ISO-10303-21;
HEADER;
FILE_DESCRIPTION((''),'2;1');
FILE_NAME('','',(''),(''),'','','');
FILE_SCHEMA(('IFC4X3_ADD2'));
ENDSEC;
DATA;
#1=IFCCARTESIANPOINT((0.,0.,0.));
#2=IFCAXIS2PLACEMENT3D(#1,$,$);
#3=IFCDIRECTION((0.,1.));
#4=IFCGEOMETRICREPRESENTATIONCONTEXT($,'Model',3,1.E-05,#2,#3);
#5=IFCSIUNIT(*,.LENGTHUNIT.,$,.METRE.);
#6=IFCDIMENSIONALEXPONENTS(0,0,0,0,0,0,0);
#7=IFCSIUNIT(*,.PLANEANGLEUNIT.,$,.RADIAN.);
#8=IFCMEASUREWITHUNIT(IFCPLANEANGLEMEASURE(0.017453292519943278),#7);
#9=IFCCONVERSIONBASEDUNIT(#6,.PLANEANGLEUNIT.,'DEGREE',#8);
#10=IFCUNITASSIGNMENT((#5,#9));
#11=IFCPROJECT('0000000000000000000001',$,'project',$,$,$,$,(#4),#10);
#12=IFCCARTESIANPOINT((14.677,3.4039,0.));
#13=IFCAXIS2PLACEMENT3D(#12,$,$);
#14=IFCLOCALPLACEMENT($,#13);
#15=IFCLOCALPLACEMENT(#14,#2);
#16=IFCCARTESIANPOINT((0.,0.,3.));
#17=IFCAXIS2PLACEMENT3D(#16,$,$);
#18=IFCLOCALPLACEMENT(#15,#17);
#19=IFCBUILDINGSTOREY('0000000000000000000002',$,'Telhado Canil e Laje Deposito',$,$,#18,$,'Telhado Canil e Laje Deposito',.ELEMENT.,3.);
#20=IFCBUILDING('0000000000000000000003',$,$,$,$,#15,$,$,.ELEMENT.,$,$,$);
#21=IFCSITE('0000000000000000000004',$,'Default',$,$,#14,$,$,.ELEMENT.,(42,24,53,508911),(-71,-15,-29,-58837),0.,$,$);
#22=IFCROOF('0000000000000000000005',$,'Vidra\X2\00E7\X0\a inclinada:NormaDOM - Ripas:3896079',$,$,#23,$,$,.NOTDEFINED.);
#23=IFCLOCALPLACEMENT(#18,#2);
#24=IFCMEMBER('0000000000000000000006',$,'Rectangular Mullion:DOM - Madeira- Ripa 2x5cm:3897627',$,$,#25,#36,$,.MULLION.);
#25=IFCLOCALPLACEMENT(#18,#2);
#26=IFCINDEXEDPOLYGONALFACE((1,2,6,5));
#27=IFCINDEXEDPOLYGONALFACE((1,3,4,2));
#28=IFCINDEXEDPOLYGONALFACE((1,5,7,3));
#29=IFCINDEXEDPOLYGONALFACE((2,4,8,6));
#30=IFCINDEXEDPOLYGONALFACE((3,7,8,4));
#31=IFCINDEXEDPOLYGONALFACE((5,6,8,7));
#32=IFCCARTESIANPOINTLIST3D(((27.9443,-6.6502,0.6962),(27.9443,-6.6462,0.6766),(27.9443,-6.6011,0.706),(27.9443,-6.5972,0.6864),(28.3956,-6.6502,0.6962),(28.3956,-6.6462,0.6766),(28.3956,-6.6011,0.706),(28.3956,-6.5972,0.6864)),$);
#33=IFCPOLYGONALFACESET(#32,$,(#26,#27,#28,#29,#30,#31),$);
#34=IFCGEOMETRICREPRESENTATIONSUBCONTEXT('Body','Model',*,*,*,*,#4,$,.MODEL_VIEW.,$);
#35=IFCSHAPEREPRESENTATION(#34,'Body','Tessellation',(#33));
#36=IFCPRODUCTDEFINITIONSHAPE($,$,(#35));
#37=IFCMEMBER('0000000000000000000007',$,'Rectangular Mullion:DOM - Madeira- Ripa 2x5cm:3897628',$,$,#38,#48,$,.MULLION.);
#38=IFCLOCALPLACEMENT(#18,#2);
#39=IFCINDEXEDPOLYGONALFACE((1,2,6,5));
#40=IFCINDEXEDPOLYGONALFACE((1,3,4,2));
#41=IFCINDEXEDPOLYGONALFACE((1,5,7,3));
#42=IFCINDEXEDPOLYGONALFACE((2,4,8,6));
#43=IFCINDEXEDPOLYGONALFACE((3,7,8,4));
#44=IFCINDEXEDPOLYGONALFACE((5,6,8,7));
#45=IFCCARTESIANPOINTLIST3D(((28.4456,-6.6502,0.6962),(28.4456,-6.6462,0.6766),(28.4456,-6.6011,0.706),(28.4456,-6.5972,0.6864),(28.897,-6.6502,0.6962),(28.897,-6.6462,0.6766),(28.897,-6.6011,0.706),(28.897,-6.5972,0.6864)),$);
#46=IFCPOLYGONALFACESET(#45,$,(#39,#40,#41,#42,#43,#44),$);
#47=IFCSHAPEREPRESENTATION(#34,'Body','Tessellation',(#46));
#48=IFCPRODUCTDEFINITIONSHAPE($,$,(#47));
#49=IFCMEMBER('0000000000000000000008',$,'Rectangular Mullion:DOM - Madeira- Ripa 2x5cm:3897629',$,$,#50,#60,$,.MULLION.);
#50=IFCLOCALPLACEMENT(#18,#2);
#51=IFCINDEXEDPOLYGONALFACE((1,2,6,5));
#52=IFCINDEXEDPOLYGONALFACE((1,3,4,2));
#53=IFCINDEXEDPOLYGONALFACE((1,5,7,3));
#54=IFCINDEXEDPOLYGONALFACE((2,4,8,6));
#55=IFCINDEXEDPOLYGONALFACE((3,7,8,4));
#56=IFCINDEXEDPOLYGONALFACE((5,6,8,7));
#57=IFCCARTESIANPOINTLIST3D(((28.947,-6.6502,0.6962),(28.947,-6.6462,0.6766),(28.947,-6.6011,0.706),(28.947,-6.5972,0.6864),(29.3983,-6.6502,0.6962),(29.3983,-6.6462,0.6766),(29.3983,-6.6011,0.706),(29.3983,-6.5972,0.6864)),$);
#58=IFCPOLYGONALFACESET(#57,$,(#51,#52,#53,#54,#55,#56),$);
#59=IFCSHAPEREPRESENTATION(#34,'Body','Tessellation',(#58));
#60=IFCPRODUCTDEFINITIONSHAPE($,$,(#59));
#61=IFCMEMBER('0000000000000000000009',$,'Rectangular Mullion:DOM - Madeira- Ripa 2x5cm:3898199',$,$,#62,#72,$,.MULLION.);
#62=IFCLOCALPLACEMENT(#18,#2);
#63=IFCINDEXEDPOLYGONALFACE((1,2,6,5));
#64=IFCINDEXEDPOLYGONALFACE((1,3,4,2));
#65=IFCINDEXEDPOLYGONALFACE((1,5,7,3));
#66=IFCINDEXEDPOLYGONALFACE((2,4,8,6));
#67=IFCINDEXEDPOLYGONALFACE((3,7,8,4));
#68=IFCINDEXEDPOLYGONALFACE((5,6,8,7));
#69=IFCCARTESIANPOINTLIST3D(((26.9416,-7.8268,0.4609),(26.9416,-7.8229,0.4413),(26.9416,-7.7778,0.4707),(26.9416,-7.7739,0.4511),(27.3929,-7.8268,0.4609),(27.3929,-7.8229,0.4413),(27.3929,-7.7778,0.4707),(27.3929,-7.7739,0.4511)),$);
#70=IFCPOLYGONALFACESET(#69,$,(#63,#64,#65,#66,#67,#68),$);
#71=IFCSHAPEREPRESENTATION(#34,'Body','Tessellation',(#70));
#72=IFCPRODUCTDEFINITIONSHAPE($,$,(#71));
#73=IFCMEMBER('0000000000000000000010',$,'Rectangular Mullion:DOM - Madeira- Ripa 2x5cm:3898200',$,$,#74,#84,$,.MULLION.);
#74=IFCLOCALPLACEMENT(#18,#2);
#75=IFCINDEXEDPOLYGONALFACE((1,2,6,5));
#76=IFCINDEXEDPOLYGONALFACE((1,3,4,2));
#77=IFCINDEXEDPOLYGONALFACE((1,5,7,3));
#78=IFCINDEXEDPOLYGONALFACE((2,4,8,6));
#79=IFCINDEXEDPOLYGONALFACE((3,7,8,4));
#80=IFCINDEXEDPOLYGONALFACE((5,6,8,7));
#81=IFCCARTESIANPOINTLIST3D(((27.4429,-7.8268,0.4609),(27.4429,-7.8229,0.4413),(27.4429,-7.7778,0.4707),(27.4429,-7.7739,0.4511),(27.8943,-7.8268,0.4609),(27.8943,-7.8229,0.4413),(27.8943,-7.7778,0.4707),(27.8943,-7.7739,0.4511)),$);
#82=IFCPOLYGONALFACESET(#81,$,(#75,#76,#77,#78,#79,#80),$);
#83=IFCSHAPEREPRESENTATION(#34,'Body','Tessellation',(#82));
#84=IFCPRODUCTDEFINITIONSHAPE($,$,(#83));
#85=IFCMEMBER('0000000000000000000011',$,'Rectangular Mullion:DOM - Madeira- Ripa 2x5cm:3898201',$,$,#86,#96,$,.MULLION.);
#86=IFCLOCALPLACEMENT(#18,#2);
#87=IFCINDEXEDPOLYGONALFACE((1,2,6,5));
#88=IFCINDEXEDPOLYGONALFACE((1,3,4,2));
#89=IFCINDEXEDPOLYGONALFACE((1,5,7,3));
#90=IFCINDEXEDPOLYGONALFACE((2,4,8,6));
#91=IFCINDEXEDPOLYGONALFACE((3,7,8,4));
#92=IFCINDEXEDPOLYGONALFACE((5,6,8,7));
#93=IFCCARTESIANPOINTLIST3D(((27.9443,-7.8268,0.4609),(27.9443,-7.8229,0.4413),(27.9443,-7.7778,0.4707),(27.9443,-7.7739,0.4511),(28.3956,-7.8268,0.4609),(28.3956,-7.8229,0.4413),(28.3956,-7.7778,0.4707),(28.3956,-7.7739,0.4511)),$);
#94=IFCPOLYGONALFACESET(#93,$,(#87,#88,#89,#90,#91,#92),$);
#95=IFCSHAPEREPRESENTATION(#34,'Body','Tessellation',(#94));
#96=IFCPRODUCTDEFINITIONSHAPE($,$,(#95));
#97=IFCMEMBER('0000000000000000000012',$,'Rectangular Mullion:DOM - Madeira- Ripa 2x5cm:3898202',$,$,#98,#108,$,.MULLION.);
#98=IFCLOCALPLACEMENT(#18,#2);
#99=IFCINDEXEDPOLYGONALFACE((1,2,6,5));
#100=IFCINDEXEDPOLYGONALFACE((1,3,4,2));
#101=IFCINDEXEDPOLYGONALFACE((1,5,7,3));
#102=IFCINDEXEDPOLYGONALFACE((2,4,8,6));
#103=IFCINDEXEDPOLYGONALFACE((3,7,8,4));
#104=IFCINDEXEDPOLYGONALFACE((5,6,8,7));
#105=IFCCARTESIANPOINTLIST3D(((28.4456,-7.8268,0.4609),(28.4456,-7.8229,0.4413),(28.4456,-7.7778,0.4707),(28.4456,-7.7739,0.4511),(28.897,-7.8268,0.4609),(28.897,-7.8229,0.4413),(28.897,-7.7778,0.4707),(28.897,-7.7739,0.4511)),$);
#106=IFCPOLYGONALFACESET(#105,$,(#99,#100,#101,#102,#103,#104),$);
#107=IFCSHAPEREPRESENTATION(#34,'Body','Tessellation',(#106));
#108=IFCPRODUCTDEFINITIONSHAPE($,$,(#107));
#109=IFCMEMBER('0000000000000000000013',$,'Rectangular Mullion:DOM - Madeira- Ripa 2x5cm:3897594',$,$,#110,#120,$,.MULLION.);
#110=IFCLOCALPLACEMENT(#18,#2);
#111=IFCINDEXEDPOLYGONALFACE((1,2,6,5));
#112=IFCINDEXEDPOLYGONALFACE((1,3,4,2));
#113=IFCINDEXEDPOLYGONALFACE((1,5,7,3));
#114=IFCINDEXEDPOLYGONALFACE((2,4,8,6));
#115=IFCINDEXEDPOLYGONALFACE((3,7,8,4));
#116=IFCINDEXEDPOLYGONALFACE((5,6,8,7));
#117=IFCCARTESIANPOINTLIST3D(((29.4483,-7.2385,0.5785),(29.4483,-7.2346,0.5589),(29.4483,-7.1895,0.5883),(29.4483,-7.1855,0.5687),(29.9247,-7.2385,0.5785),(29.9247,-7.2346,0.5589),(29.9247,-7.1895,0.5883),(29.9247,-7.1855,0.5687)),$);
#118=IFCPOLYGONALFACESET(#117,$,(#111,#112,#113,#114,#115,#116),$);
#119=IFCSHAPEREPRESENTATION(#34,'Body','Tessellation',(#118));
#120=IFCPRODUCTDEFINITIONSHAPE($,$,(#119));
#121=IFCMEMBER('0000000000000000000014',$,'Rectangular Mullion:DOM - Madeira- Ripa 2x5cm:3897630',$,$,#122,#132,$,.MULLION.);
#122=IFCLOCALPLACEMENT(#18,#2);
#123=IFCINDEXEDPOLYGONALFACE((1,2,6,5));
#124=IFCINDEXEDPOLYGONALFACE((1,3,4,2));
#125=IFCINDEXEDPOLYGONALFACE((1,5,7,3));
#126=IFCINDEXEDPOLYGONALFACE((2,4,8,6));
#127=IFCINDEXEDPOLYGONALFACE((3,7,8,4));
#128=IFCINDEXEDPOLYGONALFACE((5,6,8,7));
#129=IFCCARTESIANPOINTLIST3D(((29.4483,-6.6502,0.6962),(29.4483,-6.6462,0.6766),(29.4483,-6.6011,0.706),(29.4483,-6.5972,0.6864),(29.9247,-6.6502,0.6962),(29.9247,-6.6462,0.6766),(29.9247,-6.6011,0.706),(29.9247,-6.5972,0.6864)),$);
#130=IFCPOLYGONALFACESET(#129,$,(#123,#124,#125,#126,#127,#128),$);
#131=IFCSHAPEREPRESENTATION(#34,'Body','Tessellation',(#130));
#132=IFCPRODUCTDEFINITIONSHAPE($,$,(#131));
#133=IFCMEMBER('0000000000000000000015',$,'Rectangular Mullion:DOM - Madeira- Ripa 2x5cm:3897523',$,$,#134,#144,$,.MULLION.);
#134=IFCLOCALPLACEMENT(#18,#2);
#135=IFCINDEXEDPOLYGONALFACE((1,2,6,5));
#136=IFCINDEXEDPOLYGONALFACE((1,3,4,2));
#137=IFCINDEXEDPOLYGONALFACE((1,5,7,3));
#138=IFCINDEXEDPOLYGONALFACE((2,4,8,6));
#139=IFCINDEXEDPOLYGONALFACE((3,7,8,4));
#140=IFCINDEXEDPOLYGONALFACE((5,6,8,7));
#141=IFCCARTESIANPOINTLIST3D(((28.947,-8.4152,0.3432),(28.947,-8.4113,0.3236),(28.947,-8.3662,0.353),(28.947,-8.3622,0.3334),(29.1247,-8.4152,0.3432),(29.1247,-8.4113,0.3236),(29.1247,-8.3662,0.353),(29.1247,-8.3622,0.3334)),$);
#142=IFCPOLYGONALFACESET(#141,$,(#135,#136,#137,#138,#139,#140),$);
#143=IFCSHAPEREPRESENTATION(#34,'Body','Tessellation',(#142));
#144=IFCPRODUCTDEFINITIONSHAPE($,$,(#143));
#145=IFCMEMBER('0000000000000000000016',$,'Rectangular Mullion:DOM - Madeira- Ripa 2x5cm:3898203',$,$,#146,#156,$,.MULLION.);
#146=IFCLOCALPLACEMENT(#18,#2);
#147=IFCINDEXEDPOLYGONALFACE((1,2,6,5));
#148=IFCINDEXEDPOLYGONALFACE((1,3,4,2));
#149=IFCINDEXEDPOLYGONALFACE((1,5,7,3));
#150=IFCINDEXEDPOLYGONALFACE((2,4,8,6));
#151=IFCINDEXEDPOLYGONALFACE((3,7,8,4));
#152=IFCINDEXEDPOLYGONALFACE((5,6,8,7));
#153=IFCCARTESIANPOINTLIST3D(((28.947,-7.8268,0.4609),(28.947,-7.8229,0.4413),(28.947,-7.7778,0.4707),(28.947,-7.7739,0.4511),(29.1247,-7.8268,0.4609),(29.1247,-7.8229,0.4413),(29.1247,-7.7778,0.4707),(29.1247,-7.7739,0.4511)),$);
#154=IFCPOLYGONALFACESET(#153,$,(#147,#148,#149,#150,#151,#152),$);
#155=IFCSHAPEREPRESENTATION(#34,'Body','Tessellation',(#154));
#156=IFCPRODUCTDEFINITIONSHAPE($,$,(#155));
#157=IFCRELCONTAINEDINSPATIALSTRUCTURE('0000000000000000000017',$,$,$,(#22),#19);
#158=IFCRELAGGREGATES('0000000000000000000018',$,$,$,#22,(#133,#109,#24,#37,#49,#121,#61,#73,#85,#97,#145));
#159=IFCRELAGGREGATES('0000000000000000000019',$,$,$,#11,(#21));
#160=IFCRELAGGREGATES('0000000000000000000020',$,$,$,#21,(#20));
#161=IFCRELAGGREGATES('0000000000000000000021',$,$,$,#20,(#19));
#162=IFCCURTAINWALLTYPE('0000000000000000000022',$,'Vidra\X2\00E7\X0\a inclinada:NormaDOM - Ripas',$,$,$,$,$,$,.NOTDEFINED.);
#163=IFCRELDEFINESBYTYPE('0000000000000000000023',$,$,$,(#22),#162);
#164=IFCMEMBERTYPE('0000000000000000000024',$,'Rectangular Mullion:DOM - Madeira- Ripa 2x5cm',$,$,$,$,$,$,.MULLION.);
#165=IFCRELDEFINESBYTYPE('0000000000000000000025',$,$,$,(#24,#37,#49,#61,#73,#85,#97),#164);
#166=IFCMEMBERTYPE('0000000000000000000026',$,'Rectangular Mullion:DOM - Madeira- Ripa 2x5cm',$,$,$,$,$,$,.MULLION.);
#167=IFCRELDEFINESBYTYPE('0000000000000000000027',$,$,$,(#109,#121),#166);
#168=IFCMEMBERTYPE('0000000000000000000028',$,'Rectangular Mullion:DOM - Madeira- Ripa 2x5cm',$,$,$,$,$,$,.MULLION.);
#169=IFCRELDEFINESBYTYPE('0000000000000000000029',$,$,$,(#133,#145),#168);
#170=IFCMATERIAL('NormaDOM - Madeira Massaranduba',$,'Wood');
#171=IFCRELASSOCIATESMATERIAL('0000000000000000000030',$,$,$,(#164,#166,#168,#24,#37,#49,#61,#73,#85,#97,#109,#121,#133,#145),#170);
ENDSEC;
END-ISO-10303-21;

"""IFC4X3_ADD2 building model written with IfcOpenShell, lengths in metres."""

from ifc_helpers import new_model, entity, si_unit, converted_unit, direction, frame, origin, origin_2d_with_axis, place, context, subcontext, project, spatial, rectangle, extrude, source, transform, mapped, material, material_profile, profile_set, profile_usage, type_object, type_shapes, element, aggregate, save


model = new_model("IFC4X3_ADD2")

# Units and contexts
model_context = context("Model", 3, precision=1e-05, world=origin(), true_north=direction((0.0, 1.0)))
body_context = subcontext(model_context, "Body", "Model", "MODEL_VIEW")
ifc_project = project(units=[si_unit("LENGTHUNIT", "METRE"), converted_unit("PLANEANGLEUNIT", "DEGREE", entity("IfcPlaneAngleMeasure", 0.017453292519943278), si_unit("PLANEANGLEUNIT", "RADIAN"), dimensions=[0, 0, 0, 0, 0, 0, 0])], contexts=[model_context])

# Site, building, storey
site_placement = place(None, frame((14.677, 3.4039, 0.0)))
site = spatial("IfcSite", under=ifc_project, at=site_placement, Name="Default", CompositionType="ELEMENT", RefLatitude=(42, 24, 53, 508911), RefLongitude=(-71, -15, -29, -58837), RefElevation=0.0)
building_placement = place(site_placement, origin())
building = spatial("IfcBuilding", under=site, at=building_placement, CompositionType="ELEMENT")
storey_placement = place(building_placement, frame((0.0, 0.0, 3.0)))
storey = spatial("IfcBuildingStorey", under=building, at=storey_placement, Name="Telhado Canil e Laje Deposito", LongName="Telhado Canil e Laje Deposito", CompositionType="ELEMENT", Elevation=3.0)

# Roof
ifc_material = material(Name="NormaDOM - Madeira Massaranduba", Category="Wood")
ifc_material_profile_1 = material_profile(ifc_material, rectangle(XDim=0.05, YDim=0.02, at=origin_2d_with_axis()), Name="DOM - Madeira- Ripa 2x5cm")
ifc_profile_set_1 = profile_set([ifc_material_profile_1], Name="DOM - Madeira- Ripa 2x5cm")
ifc_profile_usage_1 = profile_usage(ifc_profile_set_1)
curtain_wall_type_1 = type_object("IfcCurtainWallType", Name="Vidraça inclinada:NormaDOM - Ripas", PredefinedType="NOTDEFINED")
roof_1_placement = place(storey_placement, frame((0.0, 0.0, -3.0)))
roof_1 = element("IfcRoof", 1, at=roof_1_placement, inside=storey, type_object=curtain_wall_type_1, Name="Vidraça inclinada:NormaDOM - Ripas:3896079", PredefinedType="NOTDEFINED")

# Members
member_type_1 = type_object("IfcMemberType", Name="Rectangular Mullion:DOM - Madeira- Ripa 2x5cm", PredefinedType="MULLION", material=ifc_profile_set_1)
shared_shape_1 = source(origin(), body_context, "Body", "SweptSolid", [
    extrude(rectangle(XDim=0.05, YDim=0.02, at=origin_2d_with_axis()), frame((0.025, 0.01, -0.4514), z_axis=(0.0, 0.0, 1.0), x_axis=(-1.0, 0.0, 0.0)), (0.0, 0.0, 1.0), 0.4514),
])
type_shapes(member_type_1, [shared_shape_1])
member_1_placement = place(roof_1_placement, frame((27.9443, -6.6502, 3.6962), z_axis=(-1.0, 0.0, 0.0), x_axis=(0.0, 0.980581, 0.196116)))
member_1 = element("IfcMember", 2, at=member_1_placement, type_object=member_type_1, material=ifc_profile_usage_1, Name="Rectangular Mullion:DOM - Madeira- Ripa 2x5cm:3897627", PredefinedType="MULLION", context=body_context, shape_type="MappedRepresentation", body=[
    mapped(shared_shape_1, transform((0.0, 0.0, 0.0), scale=1.0)),
])
member_2_placement = place(roof_1_placement, frame((28.4456, -6.6502, 3.6962), z_axis=(-1.0, 0.0, 0.0), x_axis=(0.0, 0.980581, 0.196116)))
member_2 = element("IfcMember", 3, at=member_2_placement, type_object=member_type_1, material=ifc_profile_usage_1, Name="Rectangular Mullion:DOM - Madeira- Ripa 2x5cm:3897628", PredefinedType="MULLION", context=body_context, shape_type="MappedRepresentation", body=[
    mapped(shared_shape_1, transform((0.0, 0.0, 0.0), scale=1.0)),
])
member_3_placement = place(roof_1_placement, frame((28.947, -6.6502, 3.6962), z_axis=(-1.0, 0.0, 0.0), x_axis=(0.0, 0.980581, 0.196116)))
member_3 = element("IfcMember", 4, at=member_3_placement, type_object=member_type_1, material=ifc_profile_usage_1, Name="Rectangular Mullion:DOM - Madeira- Ripa 2x5cm:3897629", PredefinedType="MULLION", context=body_context, shape_type="MappedRepresentation", body=[
    mapped(shared_shape_1, transform((0.0, 0.0, 0.0), scale=1.0)),
])
member_4_placement = place(roof_1_placement, frame((26.9416, -7.8268, 3.4609), z_axis=(-1.0, 0.0, 0.0), x_axis=(0.0, 0.980581, 0.196116)))
member_4 = element("IfcMember", 5, at=member_4_placement, type_object=member_type_1, material=ifc_profile_usage_1, Name="Rectangular Mullion:DOM - Madeira- Ripa 2x5cm:3898199", PredefinedType="MULLION", context=body_context, shape_type="MappedRepresentation", body=[
    mapped(shared_shape_1, transform((0.0, 0.0, 0.0), scale=1.0)),
])
member_5_placement = place(roof_1_placement, frame((27.4429, -7.8268, 3.4609), z_axis=(-1.0, 0.0, 0.0), x_axis=(0.0, 0.980581, 0.196116)))
member_5 = element("IfcMember", 6, at=member_5_placement, type_object=member_type_1, material=ifc_profile_usage_1, Name="Rectangular Mullion:DOM - Madeira- Ripa 2x5cm:3898200", PredefinedType="MULLION", context=body_context, shape_type="MappedRepresentation", body=[
    mapped(shared_shape_1, transform((0.0, 0.0, 0.0), scale=1.0)),
])
member_6_placement = place(roof_1_placement, frame((27.9443, -7.8268, 3.4609), z_axis=(-1.0, 0.0, 0.0), x_axis=(0.0, 0.980581, 0.196116)))
member_6 = element("IfcMember", 7, at=member_6_placement, type_object=member_type_1, material=ifc_profile_usage_1, Name="Rectangular Mullion:DOM - Madeira- Ripa 2x5cm:3898201", PredefinedType="MULLION", context=body_context, shape_type="MappedRepresentation", body=[
    mapped(shared_shape_1, transform((0.0, 0.0, 0.0), scale=1.0)),
])
member_7_placement = place(roof_1_placement, frame((28.4456, -7.8268, 3.4609), z_axis=(-1.0, 0.0, 0.0), x_axis=(0.0, 0.980581, 0.196116)))
member_7 = element("IfcMember", 8, at=member_7_placement, type_object=member_type_1, material=ifc_profile_usage_1, Name="Rectangular Mullion:DOM - Madeira- Ripa 2x5cm:3898202", PredefinedType="MULLION", context=body_context, shape_type="MappedRepresentation", body=[
    mapped(shared_shape_1, transform((0.0, 0.0, 0.0), scale=1.0)),
])
member_type_2 = type_object("IfcMemberType", Name="Rectangular Mullion:DOM - Madeira- Ripa 2x5cm", PredefinedType="MULLION", material=ifc_profile_set_1)
shared_shape_2 = source(origin(), body_context, "Body", "SweptSolid", [
    extrude(rectangle(XDim=0.05, YDim=0.02, at=origin_2d_with_axis()), frame((0.025, 0.01, -0.4764), z_axis=(0.0, 0.0, 1.0), x_axis=(-1.0, 0.0, 0.0)), (0.0, 0.0, 1.0), 0.4764),
])
type_shapes(member_type_2, [shared_shape_2])
member_8_placement = place(roof_1_placement, frame((29.4483, -7.2385, 3.5785), z_axis=(-1.0, 0.0, 0.0), x_axis=(0.0, 0.980581, 0.196116)))
member_8 = element("IfcMember", 9, at=member_8_placement, type_object=member_type_2, material=ifc_profile_usage_1, Name="Rectangular Mullion:DOM - Madeira- Ripa 2x5cm:3897594", PredefinedType="MULLION", context=body_context, shape_type="MappedRepresentation", body=[
    mapped(shared_shape_2, transform((0.0, 0.0, 0.0), scale=1.0)),
])
member_9_placement = place(roof_1_placement, frame((29.4483, -6.6502, 3.6962), z_axis=(-1.0, 0.0, 0.0), x_axis=(0.0, 0.980581, 0.196116)))
member_9 = element("IfcMember", 10, at=member_9_placement, type_object=member_type_2, material=ifc_profile_usage_1, Name="Rectangular Mullion:DOM - Madeira- Ripa 2x5cm:3897630", PredefinedType="MULLION", context=body_context, shape_type="MappedRepresentation", body=[
    mapped(shared_shape_2, transform((0.0, 0.0, 0.0), scale=1.0)),
])
member_type_3 = type_object("IfcMemberType", Name="Rectangular Mullion:DOM - Madeira- Ripa 2x5cm", PredefinedType="MULLION", material=ifc_profile_set_1)
shared_shape_3 = source(origin(), body_context, "Body", "SweptSolid", [
    extrude(rectangle(XDim=0.05, YDim=0.02, at=origin_2d_with_axis()), frame((0.025, 0.01, -0.1777), z_axis=(0.0, 0.0, 1.0), x_axis=(-1.0, 0.0, 0.0)), (0.0, 0.0, 1.0), 0.1777),
])
type_shapes(member_type_3, [shared_shape_3])
member_10_placement = place(roof_1_placement, frame((28.947, -8.4152, 3.3432), z_axis=(-1.0, 0.0, 0.0), x_axis=(0.0, 0.980581, 0.196116)))
member_10 = element("IfcMember", 11, at=member_10_placement, type_object=member_type_3, material=ifc_profile_usage_1, Name="Rectangular Mullion:DOM - Madeira- Ripa 2x5cm:3897523", PredefinedType="MULLION", context=body_context, shape_type="MappedRepresentation", body=[
    mapped(shared_shape_3, transform((0.0, 0.0, 0.0), scale=1.0)),
])
member_11_placement = place(roof_1_placement, frame((28.947, -7.8268, 3.4609), z_axis=(-1.0, 0.0, 0.0), x_axis=(0.0, 0.980581, 0.196116)))
member_11 = element("IfcMember", 12, at=member_11_placement, type_object=member_type_3, material=ifc_profile_usage_1, Name="Rectangular Mullion:DOM - Madeira- Ripa 2x5cm:3898203", PredefinedType="MULLION", context=body_context, shape_type="MappedRepresentation", body=[
    mapped(shared_shape_3, transform((0.0, 0.0, 0.0), scale=1.0)),
])
aggregate(roof_1, [member_10, member_8, member_1, member_2, member_3, member_9, member_4, member_5, member_6, member_7, member_11])

save(model, "model.ifc")
